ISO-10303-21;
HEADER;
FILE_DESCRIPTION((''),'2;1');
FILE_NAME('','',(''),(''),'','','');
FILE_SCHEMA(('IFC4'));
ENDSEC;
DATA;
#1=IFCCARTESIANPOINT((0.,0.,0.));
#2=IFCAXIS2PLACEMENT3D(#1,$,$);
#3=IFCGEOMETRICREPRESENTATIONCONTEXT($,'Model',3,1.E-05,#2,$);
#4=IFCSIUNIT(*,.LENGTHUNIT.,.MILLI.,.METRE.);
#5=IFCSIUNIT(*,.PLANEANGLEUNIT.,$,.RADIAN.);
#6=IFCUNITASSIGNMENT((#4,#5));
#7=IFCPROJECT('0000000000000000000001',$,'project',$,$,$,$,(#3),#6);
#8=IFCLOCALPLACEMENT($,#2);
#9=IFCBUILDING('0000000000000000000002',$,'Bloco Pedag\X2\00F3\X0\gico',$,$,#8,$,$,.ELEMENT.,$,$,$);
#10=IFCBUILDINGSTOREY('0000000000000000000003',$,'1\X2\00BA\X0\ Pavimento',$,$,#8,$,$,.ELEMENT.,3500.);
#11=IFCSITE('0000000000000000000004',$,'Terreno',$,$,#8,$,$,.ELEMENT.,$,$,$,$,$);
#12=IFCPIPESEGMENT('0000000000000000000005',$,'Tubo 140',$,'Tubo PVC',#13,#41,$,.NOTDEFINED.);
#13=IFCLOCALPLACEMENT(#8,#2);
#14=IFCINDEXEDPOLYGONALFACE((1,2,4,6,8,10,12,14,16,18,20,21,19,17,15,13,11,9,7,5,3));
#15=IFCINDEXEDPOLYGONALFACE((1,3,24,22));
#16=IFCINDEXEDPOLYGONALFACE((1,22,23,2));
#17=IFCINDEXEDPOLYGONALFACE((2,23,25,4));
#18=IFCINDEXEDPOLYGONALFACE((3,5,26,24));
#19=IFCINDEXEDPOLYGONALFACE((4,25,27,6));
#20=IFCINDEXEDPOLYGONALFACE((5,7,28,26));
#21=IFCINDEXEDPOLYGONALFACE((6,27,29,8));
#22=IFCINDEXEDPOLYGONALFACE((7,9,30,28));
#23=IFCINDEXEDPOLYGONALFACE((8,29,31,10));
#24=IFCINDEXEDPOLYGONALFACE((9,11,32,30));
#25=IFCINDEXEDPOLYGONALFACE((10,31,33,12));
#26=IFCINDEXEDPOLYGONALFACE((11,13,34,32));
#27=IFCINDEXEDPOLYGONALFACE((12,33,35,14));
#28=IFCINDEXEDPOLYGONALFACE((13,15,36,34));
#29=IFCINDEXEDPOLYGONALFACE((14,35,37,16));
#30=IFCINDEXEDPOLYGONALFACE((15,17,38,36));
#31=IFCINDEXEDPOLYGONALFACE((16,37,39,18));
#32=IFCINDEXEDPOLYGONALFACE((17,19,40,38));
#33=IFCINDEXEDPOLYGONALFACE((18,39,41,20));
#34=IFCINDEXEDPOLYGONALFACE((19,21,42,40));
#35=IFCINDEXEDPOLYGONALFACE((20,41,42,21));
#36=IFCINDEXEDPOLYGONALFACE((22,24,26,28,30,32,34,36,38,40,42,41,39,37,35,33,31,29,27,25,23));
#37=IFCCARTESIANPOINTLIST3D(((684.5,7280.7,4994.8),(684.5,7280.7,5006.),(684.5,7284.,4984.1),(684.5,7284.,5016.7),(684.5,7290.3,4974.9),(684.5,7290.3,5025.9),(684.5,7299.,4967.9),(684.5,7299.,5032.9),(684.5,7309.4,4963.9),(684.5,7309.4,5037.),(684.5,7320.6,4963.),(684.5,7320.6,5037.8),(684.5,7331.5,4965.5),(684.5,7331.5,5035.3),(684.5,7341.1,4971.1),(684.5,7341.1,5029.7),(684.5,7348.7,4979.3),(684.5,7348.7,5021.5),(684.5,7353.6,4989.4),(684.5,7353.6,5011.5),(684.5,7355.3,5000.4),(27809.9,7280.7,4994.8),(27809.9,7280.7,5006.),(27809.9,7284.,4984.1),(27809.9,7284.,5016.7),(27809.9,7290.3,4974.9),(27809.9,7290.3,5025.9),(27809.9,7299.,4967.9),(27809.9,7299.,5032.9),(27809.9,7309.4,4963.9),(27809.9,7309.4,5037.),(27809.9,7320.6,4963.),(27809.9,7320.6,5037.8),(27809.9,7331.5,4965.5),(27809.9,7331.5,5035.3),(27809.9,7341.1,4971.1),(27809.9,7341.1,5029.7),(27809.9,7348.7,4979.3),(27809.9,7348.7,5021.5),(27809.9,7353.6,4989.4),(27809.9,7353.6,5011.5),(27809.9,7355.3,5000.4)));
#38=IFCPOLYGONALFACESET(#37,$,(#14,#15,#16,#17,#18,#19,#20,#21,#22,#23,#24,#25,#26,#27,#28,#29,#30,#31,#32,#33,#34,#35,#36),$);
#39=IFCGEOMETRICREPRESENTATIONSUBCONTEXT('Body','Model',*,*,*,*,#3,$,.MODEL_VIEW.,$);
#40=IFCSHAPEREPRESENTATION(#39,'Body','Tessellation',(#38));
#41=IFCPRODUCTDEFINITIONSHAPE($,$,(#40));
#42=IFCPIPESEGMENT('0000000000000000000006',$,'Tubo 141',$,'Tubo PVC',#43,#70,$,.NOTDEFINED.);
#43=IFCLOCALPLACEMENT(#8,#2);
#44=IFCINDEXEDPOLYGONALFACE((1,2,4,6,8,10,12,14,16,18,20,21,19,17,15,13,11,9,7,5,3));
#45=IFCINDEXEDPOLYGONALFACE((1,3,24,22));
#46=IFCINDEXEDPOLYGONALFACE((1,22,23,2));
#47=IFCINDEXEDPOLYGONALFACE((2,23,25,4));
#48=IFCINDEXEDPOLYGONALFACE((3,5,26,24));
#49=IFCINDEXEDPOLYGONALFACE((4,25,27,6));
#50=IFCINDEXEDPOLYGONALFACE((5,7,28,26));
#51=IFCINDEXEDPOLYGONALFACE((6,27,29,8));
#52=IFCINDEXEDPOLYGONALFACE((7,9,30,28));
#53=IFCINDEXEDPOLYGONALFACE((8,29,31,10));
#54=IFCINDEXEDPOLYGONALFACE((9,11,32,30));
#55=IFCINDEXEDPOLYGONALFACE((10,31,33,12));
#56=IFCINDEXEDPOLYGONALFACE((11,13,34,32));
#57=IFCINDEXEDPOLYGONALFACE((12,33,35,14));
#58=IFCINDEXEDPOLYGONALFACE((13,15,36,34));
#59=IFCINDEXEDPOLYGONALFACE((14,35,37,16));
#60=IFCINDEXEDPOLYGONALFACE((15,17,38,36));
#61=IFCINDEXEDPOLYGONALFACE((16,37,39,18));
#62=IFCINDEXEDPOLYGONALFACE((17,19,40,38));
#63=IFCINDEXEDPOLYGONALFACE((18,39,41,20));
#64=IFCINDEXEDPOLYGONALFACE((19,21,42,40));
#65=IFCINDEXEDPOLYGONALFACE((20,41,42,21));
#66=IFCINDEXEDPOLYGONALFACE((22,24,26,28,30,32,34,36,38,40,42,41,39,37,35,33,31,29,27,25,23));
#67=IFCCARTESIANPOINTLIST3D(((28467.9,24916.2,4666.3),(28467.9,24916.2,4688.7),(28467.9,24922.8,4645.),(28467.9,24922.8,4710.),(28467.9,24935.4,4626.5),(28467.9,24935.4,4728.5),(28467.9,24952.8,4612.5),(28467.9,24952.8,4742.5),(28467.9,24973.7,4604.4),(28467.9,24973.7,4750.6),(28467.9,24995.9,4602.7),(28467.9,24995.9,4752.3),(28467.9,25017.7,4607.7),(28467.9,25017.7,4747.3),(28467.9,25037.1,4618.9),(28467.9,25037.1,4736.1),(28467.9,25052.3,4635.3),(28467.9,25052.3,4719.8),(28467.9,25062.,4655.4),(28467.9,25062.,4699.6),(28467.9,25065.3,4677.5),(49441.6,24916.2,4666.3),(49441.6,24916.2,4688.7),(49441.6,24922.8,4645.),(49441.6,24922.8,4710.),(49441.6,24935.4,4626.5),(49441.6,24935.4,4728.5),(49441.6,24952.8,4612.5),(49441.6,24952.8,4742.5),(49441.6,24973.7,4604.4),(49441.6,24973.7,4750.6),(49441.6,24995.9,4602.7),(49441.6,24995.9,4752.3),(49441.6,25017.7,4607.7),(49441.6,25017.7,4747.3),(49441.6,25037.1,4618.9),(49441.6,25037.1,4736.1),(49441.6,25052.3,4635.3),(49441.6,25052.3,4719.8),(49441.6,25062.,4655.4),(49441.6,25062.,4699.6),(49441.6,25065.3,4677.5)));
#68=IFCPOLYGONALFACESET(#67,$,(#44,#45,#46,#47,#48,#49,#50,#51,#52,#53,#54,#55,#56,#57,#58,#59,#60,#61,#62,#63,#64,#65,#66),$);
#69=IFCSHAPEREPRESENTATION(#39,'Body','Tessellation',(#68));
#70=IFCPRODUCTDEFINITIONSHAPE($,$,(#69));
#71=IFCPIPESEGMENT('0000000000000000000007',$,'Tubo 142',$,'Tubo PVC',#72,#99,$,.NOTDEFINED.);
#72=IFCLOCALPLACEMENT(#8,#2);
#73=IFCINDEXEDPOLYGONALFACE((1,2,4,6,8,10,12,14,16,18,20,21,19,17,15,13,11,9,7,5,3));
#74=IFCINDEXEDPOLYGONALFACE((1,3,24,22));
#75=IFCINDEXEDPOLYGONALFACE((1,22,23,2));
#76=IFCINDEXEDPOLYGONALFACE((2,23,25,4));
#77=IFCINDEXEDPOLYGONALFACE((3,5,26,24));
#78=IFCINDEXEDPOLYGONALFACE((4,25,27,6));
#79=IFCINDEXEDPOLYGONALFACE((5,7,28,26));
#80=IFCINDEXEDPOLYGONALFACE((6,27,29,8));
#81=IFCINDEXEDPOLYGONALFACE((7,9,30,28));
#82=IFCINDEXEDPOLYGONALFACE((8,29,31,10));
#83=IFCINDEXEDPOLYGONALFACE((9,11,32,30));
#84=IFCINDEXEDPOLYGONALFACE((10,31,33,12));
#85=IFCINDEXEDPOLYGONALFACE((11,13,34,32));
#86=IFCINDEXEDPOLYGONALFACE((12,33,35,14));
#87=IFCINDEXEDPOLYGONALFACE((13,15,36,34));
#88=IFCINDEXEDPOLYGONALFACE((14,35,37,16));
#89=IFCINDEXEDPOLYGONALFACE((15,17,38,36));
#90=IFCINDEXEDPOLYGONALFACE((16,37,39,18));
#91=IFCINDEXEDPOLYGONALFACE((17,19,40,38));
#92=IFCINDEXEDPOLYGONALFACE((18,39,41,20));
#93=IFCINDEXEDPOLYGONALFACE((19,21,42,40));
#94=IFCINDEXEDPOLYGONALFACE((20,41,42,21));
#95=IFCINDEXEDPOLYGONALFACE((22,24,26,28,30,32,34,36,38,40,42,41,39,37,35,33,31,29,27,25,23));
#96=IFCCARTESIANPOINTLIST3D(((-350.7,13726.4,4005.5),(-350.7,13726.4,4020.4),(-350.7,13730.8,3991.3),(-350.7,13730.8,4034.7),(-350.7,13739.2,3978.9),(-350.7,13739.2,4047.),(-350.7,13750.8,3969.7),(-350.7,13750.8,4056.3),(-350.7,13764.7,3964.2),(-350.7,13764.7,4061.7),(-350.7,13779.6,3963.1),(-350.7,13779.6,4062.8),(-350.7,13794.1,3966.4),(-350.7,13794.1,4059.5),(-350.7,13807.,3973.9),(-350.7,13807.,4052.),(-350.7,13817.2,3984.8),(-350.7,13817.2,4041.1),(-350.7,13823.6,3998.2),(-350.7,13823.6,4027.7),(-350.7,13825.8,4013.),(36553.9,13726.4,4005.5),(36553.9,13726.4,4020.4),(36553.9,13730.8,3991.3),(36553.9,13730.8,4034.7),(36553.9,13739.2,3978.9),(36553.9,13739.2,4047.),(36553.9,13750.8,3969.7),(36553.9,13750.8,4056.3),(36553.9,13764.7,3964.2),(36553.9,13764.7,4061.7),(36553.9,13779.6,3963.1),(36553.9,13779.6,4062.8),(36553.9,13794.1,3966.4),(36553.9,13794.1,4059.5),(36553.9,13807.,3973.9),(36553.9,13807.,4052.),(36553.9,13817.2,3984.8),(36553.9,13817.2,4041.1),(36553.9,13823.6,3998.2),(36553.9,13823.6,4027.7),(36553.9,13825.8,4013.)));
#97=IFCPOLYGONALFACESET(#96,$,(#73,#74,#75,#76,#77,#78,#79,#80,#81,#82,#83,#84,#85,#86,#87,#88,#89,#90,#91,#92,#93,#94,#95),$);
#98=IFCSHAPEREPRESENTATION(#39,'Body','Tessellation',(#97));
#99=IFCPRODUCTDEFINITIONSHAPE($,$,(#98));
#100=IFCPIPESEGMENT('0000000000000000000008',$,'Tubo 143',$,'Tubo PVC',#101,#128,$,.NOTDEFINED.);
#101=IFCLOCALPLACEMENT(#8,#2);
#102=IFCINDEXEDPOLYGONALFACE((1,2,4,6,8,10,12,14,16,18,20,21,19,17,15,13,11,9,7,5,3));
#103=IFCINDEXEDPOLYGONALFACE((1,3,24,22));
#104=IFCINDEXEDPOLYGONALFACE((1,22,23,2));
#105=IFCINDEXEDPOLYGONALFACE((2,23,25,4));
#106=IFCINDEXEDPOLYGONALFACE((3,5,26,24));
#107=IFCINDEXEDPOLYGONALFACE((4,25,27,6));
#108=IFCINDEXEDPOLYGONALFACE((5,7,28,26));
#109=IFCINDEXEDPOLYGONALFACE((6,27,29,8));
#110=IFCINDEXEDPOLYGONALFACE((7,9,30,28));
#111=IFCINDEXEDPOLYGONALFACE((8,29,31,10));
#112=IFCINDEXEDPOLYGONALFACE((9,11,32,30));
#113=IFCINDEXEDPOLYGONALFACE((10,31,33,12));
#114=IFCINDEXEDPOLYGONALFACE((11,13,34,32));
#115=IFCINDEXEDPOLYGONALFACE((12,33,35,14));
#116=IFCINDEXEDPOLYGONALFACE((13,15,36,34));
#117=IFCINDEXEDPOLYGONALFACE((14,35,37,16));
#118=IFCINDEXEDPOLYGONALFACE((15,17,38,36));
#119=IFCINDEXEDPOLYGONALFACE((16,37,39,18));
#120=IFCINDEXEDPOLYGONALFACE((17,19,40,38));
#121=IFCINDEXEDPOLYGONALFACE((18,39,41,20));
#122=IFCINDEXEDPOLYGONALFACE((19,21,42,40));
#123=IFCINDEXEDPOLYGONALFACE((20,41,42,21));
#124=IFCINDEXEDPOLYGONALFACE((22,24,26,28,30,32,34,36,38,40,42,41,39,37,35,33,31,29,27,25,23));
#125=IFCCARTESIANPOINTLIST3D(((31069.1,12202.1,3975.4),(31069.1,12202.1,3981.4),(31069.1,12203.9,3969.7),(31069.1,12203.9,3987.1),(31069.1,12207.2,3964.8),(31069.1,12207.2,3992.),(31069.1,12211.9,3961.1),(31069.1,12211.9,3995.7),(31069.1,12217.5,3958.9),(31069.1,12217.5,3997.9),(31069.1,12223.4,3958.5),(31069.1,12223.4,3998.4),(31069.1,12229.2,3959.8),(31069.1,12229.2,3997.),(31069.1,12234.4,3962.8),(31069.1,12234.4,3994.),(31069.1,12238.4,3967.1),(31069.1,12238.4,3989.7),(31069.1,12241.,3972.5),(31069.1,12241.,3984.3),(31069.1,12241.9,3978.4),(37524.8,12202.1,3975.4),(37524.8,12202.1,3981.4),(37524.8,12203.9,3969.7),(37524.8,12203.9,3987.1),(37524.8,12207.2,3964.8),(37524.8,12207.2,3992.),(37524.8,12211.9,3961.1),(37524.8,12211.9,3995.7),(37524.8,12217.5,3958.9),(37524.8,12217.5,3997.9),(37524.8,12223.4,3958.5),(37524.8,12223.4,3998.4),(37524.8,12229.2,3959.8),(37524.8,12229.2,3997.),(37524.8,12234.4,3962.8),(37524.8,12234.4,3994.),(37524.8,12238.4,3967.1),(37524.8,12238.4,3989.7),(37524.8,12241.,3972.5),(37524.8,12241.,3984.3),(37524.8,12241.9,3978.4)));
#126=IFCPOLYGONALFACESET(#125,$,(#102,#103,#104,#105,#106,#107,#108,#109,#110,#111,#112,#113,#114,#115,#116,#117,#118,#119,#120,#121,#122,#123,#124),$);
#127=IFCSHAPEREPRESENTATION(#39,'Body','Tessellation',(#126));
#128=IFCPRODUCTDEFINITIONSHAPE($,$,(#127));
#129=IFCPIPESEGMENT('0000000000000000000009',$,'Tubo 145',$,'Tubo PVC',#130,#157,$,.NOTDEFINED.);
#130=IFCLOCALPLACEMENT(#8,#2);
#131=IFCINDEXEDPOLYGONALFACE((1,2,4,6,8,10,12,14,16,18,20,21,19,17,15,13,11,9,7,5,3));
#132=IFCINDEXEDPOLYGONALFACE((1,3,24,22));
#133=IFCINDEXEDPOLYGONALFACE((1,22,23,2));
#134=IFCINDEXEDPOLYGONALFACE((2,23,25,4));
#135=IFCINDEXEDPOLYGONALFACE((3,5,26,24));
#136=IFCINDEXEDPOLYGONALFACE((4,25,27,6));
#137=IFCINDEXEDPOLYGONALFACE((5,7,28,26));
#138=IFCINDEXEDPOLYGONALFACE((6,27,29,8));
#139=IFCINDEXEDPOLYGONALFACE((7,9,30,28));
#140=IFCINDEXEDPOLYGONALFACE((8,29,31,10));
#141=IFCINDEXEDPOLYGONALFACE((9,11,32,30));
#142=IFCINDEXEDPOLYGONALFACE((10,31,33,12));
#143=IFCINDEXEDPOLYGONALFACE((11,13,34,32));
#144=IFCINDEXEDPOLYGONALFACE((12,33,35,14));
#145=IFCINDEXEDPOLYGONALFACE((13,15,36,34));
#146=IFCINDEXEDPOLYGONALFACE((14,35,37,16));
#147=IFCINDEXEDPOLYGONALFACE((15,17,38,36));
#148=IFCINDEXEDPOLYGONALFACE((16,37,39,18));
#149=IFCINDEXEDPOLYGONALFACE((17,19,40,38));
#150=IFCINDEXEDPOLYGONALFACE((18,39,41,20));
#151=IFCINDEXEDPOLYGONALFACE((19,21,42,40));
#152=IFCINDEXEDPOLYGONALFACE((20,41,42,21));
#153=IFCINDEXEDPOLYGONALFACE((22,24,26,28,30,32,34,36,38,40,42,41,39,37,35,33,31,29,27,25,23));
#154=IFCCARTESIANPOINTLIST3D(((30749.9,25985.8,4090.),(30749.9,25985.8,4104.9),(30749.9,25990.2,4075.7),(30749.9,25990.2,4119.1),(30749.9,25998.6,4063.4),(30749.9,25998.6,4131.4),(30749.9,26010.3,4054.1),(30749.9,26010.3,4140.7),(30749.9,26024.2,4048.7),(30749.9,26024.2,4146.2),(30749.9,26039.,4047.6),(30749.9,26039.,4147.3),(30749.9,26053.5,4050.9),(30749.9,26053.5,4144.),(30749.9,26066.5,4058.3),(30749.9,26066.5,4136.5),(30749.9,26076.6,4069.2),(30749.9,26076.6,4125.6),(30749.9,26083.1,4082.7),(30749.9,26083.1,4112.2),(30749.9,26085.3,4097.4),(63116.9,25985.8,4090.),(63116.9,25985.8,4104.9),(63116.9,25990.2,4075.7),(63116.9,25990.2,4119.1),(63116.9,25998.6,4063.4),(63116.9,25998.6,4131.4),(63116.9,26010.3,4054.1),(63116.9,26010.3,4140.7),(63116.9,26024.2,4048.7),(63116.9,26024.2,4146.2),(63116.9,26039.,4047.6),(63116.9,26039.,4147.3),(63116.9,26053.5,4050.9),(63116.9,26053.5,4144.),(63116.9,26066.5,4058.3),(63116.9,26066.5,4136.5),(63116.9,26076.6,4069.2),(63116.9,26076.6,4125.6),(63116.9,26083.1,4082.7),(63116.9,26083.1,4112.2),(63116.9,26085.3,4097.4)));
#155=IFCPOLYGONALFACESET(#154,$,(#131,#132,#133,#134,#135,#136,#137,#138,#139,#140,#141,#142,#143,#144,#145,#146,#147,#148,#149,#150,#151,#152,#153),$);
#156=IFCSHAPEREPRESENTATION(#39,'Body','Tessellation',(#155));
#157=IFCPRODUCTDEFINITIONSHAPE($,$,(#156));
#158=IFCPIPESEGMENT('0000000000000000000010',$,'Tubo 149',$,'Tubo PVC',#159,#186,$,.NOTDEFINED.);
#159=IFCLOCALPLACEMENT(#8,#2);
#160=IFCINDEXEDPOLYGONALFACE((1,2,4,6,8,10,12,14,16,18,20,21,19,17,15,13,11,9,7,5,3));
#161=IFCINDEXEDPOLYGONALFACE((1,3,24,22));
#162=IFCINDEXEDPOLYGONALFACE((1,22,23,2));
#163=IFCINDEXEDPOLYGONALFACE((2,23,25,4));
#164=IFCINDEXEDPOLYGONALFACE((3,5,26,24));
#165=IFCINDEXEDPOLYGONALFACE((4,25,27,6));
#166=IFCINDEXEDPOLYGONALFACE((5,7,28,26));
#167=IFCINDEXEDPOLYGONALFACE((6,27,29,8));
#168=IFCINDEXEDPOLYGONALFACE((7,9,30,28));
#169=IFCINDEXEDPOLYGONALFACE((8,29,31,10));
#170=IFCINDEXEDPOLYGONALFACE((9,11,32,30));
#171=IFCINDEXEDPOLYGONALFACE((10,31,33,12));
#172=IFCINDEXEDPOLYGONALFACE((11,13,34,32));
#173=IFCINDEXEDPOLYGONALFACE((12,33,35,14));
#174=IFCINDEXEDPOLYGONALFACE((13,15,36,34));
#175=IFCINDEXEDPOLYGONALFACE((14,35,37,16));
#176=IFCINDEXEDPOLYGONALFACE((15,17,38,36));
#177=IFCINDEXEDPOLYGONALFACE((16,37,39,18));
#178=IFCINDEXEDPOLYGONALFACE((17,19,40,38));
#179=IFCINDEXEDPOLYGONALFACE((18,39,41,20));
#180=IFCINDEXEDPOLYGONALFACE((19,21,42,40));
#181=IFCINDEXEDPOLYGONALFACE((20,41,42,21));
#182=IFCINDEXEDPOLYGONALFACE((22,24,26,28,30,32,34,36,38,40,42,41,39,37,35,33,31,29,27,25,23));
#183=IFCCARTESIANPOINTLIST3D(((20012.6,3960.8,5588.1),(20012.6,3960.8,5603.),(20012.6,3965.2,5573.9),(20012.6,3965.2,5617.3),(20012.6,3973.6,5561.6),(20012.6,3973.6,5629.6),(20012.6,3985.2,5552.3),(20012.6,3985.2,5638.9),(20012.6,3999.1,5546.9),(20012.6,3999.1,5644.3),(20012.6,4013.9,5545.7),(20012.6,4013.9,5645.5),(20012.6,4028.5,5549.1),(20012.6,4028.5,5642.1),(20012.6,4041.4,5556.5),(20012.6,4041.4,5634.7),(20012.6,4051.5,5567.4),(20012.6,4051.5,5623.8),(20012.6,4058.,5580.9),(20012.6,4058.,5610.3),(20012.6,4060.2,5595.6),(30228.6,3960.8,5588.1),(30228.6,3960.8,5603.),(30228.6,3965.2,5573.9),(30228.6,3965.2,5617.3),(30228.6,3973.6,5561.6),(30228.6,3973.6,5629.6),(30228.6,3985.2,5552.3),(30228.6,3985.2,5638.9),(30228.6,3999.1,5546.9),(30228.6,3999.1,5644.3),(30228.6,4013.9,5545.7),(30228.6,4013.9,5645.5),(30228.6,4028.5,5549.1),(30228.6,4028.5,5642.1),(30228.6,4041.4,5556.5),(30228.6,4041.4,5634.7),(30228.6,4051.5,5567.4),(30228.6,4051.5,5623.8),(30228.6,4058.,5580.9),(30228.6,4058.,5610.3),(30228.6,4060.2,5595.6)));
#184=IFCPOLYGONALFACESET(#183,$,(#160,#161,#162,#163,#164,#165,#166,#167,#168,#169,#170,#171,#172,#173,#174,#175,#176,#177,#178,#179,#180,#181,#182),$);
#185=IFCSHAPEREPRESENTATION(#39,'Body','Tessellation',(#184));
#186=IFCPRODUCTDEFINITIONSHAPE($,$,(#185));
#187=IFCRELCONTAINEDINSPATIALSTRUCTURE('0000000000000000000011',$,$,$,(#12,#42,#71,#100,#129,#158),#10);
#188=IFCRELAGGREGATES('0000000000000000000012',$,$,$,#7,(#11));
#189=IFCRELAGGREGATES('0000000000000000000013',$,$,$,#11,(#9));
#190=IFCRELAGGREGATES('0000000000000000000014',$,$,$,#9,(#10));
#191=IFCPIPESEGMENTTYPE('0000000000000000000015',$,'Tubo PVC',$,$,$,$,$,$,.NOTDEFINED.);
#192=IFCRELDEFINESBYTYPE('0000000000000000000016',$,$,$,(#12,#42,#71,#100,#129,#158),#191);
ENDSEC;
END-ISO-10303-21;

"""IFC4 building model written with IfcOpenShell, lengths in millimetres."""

from ifc_helpers import new_model, si_unit, frame, origin, origin_2d, place, context, subcontext, project, spatial, circle, extrude, type_object, element, save


model = new_model("IFC4")

# Units and contexts
model_context = context("Model", 3, precision=1e-05, world=origin())
body_context = subcontext(model_context, "Body", "Model", "MODEL_VIEW")
ifc_project = project(units=[si_unit("LENGTHUNIT", "METRE", prefix="MILLI"), si_unit("PLANEANGLEUNIT", "RADIAN")], contexts=[model_context])

# Site, building, storey
placement = place(None, origin())
site = spatial("IfcSite", under=ifc_project, at=placement, Name="Terreno", CompositionType="ELEMENT")
building = spatial("IfcBuilding", under=site, at=placement, Name="Bloco Pedagógico", CompositionType="ELEMENT")
storey = spatial("IfcBuildingStorey", under=building, at=placement, Name="1º Pavimento", CompositionType="ELEMENT", Elevation=3500.0)

# Pipe segments
pipe_segment_type = type_object("IfcPipeSegmentType", Name="Tubo PVC", PredefinedType="NOTDEFINED")
pipe_segment_1_placement = place(None, frame((684.5, 7317.8, 5000.4), z_axis=(1.0, 0.0, 0.0), x_axis=(0.0, 1.0, 0.0)))
element("IfcPipeSegment", 1, at=pipe_segment_1_placement, inside=storey, type_object=pipe_segment_type, Name="Tubo 140", ObjectType="Tubo PVC", PredefinedType="NOTDEFINED", context=body_context, shape_type="SweptSolid", body=[
    extrude(circle(Radius=37.5, at=origin_2d()), None, (0.0, 0.0, 1.0), 27125.3),
])
pipe_segment_2_placement = place(None, frame((28467.9, 24990.3, 4677.5), z_axis=(1.0, 0.0, 0.0), x_axis=(0.0, 1.0, 0.0)))
element("IfcPipeSegment", 2, at=pipe_segment_2_placement, inside=storey, type_object=pipe_segment_type, Name="Tubo 141", ObjectType="Tubo PVC", PredefinedType="NOTDEFINED", context=body_context, shape_type="SweptSolid", body=[
    extrude(circle(Radius=75.0, at=origin_2d()), None, (0.0, 0.0, 1.0), 20973.7),
])
pipe_segment_3_placement = place(None, frame((-350.7, 13775.8, 4013.0), z_axis=(1.0, 0.0, 0.0), x_axis=(0.0, 1.0, 0.0)))
element("IfcPipeSegment", 3, at=pipe_segment_3_placement, inside=storey, type_object=pipe_segment_type, Name="Tubo 142", ObjectType="Tubo PVC", PredefinedType="NOTDEFINED", context=body_context, shape_type="SweptSolid", body=[
    extrude(circle(Radius=50.0, at=origin_2d()), None, (0.0, 0.0, 1.0), 36904.6),
])
pipe_segment_4_placement = place(None, frame((31069.1, 12221.9, 3978.4), z_axis=(1.0, 0.0, 0.0), x_axis=(0.0, 1.0, 0.0)))
element("IfcPipeSegment", 4, at=pipe_segment_4_placement, inside=storey, type_object=pipe_segment_type, Name="Tubo 143", ObjectType="Tubo PVC", PredefinedType="NOTDEFINED", context=body_context, shape_type="SweptSolid", body=[
    extrude(circle(Radius=20.0, at=origin_2d()), None, (0.0, 0.0, 1.0), 6455.7),
])
pipe_segment_5_placement = place(None, frame((30749.9, 26035.3, 4097.4), z_axis=(1.0, 0.0, 0.0), x_axis=(0.0, 1.0, 0.0)))
element("IfcPipeSegment", 5, at=pipe_segment_5_placement, inside=storey, type_object=pipe_segment_type, Name="Tubo 145", ObjectType="Tubo PVC", PredefinedType="NOTDEFINED", context=body_context, shape_type="SweptSolid", body=[
    extrude(circle(Radius=50.0, at=origin_2d()), None, (0.0, 0.0, 1.0), 32367.1),
])
pipe_segment_6_placement = place(None, frame((20012.6, 4010.2, 5595.6), z_axis=(1.0, 0.0, 0.0), x_axis=(0.0, 1.0, 0.0)))
element("IfcPipeSegment", 6, at=pipe_segment_6_placement, inside=storey, type_object=pipe_segment_type, Name="Tubo 149", ObjectType="Tubo PVC", PredefinedType="NOTDEFINED", context=body_context, shape_type="SweptSolid", body=[
    extrude(circle(Radius=50.0, at=origin_2d()), None, (0.0, 0.0, 1.0), 10216.0),
])

save(model, "model.ifc")
